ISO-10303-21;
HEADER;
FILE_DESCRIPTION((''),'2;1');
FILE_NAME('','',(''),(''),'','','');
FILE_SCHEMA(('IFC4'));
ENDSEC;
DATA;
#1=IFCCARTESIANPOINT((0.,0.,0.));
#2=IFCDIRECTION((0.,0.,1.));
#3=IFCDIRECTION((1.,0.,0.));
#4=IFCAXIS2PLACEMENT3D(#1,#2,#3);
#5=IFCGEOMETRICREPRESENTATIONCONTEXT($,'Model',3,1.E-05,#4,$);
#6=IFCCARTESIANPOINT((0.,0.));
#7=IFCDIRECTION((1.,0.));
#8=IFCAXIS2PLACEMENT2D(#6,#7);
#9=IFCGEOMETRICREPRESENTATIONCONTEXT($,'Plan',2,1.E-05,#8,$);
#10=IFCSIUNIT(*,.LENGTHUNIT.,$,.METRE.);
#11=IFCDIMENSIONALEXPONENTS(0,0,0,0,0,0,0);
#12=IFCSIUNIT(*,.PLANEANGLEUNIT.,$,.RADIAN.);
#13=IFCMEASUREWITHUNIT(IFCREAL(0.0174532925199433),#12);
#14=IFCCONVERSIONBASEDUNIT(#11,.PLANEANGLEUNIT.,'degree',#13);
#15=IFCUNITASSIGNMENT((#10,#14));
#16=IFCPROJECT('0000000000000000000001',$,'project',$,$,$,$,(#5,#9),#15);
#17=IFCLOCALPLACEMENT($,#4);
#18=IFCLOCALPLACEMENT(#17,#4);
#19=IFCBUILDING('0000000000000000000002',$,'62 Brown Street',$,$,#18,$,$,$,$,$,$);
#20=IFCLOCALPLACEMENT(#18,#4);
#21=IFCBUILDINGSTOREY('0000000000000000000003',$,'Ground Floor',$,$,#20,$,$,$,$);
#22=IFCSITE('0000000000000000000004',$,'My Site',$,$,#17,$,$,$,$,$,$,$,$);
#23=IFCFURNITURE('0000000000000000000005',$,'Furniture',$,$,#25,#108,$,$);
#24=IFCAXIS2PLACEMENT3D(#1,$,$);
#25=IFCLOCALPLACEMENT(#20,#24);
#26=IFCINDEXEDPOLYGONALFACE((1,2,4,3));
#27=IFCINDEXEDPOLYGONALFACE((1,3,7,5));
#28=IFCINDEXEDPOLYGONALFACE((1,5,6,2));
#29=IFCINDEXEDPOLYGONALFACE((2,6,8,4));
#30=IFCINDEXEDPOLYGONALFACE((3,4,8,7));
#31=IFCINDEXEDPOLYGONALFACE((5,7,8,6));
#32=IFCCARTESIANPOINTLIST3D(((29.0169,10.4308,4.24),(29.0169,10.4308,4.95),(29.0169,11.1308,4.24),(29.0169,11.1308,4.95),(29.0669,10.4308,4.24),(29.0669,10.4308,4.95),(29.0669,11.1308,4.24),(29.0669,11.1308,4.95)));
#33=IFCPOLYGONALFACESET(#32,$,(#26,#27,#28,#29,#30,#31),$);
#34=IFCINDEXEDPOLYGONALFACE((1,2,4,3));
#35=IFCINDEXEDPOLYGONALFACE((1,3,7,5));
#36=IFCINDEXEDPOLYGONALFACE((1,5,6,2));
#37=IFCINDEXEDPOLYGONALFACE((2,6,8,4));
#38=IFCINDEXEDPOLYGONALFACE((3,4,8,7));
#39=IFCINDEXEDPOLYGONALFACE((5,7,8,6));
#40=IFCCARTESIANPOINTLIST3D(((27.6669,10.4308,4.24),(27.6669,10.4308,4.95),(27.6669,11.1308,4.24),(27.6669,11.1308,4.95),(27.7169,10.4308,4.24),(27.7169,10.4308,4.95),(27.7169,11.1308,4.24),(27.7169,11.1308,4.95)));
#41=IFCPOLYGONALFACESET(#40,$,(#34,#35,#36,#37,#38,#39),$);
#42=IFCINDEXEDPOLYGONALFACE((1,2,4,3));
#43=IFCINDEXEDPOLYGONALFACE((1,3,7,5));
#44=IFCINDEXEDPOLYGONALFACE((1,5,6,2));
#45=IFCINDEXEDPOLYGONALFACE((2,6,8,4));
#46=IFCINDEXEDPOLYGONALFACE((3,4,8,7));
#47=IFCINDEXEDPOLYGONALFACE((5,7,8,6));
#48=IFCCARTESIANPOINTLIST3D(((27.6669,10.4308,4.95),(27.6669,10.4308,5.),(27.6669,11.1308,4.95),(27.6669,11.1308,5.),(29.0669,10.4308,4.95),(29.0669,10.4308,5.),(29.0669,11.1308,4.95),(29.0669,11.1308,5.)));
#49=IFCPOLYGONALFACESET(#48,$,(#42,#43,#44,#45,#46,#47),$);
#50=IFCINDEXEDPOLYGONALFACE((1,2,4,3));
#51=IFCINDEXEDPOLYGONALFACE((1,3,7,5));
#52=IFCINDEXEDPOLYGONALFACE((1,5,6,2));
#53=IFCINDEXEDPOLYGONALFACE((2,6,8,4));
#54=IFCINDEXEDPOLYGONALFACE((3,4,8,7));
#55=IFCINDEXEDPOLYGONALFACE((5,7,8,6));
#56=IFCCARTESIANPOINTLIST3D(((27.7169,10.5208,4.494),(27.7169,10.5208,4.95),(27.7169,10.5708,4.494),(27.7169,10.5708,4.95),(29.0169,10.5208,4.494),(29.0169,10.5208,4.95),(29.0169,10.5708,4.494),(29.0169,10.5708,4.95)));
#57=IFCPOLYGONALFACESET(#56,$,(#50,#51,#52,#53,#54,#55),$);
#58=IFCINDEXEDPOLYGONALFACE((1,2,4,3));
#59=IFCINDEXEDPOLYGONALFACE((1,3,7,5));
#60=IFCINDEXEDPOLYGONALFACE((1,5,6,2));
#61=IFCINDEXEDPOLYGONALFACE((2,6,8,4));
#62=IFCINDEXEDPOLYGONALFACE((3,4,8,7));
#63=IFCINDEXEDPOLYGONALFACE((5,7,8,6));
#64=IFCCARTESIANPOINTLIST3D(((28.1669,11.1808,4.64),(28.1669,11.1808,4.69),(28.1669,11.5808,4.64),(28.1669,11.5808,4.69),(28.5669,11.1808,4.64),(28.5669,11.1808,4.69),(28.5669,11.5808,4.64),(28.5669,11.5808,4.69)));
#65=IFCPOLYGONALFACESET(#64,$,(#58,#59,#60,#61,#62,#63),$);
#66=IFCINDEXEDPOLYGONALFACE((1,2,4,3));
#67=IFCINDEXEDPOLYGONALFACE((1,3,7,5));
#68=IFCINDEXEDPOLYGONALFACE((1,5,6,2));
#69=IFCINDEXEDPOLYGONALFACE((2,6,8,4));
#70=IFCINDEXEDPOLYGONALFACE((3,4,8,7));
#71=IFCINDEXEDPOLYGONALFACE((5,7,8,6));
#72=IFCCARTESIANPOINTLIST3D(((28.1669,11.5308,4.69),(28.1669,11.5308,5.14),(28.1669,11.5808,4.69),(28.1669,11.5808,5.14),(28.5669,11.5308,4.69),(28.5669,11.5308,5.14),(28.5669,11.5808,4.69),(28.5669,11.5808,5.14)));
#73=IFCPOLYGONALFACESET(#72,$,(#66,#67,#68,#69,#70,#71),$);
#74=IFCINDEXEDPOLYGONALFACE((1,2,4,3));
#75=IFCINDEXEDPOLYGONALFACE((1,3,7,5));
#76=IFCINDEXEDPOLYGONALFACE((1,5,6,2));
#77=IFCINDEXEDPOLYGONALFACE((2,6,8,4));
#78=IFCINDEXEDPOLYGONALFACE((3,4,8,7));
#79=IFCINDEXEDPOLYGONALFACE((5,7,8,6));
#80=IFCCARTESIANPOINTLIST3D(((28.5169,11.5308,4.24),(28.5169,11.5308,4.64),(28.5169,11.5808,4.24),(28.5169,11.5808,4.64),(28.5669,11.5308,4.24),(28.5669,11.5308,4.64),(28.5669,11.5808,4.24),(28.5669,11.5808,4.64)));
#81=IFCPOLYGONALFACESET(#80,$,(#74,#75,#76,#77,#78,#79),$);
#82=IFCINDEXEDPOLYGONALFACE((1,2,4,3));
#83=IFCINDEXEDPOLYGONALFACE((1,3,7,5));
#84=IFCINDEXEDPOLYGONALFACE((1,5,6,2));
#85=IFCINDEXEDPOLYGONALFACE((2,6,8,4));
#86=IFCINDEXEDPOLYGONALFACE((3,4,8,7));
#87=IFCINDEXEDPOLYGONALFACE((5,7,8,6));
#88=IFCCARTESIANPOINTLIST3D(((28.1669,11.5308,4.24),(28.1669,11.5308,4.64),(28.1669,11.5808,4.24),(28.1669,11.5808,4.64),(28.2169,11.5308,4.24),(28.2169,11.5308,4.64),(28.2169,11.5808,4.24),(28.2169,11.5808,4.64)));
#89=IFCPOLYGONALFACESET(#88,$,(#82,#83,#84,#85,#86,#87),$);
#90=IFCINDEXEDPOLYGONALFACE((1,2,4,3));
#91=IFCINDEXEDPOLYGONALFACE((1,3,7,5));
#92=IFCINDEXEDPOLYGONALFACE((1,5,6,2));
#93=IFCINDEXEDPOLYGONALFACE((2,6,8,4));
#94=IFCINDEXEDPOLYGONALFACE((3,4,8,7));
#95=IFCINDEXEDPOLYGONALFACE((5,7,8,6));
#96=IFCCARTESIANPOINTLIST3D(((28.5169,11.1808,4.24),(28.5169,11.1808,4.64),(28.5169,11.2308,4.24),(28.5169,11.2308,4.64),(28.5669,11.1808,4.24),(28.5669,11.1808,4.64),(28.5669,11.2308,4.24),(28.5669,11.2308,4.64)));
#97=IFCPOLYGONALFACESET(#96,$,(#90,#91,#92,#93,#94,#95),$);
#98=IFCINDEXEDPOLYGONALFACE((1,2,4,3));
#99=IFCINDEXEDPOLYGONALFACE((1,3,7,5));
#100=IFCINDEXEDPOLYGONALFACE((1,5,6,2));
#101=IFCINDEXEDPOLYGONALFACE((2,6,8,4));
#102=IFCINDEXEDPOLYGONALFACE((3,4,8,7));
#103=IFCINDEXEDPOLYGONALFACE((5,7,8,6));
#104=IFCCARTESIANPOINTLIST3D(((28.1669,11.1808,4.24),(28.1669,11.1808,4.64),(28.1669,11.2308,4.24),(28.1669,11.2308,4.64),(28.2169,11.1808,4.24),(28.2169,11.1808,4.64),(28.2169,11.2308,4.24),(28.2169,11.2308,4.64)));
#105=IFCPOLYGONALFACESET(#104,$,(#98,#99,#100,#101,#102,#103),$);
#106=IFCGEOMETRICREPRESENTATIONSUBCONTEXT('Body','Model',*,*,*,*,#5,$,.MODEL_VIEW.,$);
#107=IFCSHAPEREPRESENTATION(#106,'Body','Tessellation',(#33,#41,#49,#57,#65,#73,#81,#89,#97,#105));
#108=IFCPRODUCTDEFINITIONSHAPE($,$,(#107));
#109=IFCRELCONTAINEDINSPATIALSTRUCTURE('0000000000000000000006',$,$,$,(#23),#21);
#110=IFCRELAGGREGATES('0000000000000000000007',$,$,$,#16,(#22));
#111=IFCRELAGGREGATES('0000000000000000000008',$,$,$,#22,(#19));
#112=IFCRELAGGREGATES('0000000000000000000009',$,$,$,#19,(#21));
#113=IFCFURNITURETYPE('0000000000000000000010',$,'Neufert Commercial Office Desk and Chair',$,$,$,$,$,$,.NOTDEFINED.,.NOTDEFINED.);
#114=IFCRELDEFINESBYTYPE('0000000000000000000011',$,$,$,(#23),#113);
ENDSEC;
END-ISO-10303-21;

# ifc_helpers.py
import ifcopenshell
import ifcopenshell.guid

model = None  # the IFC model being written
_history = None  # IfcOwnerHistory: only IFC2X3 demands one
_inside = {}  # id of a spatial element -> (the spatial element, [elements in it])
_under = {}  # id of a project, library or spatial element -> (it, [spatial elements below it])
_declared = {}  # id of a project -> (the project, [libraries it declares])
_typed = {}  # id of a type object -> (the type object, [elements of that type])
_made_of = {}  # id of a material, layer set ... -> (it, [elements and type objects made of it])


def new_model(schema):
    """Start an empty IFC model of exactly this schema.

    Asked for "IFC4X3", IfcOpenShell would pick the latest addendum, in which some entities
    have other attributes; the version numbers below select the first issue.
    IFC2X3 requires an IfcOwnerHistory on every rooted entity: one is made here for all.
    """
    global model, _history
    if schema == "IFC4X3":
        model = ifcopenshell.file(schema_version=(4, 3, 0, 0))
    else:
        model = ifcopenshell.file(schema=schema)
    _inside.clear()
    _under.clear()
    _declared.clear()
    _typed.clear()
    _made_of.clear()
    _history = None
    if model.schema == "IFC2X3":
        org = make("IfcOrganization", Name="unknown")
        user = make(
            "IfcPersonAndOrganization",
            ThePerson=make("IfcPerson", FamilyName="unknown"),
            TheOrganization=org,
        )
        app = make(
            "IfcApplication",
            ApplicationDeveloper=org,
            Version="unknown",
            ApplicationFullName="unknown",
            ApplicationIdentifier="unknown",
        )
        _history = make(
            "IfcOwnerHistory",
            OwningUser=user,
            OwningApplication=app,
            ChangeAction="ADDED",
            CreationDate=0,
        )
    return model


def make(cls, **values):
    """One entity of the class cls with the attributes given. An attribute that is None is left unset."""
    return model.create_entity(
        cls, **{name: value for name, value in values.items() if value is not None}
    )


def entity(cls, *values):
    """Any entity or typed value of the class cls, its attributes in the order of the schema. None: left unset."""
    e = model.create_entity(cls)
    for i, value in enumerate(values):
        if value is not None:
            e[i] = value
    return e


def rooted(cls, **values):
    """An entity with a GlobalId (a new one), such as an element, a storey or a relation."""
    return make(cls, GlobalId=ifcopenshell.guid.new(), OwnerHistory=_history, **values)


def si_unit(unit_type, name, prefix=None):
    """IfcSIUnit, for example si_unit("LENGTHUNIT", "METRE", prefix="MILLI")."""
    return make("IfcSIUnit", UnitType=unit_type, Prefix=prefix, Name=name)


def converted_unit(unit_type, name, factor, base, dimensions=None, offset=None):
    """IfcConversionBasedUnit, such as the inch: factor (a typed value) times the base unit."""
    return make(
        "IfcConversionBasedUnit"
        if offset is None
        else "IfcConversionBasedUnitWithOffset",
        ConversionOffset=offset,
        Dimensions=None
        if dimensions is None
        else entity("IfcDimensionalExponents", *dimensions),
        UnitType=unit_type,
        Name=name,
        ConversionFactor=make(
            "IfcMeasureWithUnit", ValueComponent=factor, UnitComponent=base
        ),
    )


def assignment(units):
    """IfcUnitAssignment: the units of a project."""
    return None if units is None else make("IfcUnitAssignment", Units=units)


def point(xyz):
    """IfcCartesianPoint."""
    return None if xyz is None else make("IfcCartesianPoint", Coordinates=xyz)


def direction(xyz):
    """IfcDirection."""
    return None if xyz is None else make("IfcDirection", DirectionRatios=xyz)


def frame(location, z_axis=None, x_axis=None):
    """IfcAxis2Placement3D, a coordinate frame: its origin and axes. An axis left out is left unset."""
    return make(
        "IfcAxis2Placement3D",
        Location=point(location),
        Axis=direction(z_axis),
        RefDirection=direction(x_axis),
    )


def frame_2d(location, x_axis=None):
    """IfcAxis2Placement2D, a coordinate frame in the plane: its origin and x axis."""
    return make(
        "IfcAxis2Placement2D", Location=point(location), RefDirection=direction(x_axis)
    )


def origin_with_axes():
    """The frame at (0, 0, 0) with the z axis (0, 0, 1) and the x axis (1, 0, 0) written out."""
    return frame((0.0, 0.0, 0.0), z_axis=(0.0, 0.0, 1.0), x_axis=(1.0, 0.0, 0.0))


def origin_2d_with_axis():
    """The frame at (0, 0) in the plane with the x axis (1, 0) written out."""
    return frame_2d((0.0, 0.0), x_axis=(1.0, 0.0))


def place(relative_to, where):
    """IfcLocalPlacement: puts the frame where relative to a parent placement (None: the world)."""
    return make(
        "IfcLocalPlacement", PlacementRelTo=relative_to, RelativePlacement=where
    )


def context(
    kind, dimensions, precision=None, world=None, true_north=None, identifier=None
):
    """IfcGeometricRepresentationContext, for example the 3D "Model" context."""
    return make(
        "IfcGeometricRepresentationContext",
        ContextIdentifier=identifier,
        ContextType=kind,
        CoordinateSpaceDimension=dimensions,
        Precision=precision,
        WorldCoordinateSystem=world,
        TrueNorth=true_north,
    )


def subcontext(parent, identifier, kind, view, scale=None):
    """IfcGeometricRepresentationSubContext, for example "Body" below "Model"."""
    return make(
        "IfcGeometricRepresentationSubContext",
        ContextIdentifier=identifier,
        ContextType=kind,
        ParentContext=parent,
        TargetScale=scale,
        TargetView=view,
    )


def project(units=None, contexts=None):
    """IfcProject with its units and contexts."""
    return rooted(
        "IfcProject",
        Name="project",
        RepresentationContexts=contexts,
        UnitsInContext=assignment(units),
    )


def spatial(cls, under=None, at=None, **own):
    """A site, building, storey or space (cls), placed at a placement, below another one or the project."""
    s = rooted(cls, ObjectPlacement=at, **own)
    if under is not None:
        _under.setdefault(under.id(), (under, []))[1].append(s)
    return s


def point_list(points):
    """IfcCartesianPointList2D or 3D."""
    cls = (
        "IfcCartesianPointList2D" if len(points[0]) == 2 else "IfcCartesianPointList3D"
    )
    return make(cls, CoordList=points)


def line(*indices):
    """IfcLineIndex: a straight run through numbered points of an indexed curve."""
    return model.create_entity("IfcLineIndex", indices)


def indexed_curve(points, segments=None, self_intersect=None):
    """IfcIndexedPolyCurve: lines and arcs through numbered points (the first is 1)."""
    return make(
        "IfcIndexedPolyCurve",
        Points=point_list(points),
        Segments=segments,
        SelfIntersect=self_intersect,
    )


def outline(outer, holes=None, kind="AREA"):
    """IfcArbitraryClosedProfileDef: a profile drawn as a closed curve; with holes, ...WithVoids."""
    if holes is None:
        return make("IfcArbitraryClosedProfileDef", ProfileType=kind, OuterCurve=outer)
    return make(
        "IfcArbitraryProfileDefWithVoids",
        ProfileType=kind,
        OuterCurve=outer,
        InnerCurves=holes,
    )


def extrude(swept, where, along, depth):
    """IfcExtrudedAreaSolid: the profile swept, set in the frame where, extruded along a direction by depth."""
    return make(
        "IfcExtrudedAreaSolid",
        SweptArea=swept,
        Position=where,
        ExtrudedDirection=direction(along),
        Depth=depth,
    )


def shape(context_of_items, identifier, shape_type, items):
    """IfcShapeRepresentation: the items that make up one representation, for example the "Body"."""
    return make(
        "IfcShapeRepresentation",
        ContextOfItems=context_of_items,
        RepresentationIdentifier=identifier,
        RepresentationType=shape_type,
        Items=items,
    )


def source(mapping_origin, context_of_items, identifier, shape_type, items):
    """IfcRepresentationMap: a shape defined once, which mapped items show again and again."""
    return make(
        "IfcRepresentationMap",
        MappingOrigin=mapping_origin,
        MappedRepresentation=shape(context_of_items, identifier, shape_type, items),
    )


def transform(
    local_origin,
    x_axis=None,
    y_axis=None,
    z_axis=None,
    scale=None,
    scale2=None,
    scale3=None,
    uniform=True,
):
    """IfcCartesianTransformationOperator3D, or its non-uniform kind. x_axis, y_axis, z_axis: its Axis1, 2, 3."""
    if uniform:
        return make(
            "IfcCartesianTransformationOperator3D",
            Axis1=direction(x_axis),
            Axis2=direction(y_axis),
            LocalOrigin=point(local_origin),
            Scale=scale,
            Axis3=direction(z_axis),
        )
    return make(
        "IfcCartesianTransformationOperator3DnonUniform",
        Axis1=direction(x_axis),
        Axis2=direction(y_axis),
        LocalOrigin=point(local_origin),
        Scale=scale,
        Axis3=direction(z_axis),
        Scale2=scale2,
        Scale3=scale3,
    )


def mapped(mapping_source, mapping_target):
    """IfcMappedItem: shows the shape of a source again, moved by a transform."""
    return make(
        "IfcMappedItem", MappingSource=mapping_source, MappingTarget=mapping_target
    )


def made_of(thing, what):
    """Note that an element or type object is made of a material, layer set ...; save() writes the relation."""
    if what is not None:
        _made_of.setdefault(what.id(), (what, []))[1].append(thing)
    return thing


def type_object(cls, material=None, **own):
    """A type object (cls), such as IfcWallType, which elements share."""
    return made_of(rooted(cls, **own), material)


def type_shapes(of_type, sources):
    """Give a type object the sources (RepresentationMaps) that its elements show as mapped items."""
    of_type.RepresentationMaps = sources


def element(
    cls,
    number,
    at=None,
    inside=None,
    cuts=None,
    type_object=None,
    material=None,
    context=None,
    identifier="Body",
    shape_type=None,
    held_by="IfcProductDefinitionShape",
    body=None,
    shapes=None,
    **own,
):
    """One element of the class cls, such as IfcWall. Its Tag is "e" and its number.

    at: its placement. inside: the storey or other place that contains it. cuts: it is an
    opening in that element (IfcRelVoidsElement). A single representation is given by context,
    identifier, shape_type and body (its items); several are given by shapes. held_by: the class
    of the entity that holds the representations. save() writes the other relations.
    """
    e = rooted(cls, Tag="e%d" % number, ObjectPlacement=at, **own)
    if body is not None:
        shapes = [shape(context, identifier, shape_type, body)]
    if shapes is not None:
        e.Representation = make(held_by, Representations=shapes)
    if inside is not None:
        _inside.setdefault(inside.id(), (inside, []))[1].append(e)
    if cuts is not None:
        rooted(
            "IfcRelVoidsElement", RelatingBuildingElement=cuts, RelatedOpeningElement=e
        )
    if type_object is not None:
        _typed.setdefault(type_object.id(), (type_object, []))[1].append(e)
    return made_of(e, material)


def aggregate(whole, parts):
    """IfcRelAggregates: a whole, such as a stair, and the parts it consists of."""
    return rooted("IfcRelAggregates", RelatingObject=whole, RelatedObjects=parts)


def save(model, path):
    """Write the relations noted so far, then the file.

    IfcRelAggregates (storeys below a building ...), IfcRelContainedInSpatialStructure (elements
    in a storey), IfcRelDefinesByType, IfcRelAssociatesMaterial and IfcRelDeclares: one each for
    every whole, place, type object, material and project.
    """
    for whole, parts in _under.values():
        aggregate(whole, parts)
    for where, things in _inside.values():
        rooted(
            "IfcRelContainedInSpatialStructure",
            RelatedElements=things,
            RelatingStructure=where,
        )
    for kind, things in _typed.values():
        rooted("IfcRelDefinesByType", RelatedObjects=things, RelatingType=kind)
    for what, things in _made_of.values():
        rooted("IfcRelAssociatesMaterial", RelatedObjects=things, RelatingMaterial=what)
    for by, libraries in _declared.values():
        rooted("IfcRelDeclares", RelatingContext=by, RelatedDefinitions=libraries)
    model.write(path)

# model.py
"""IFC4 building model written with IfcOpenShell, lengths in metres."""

from ifc_helpers import new_model, entity, si_unit, converted_unit, frame, origin_with_axes, origin_2d_with_axis, place, context, subcontext, project, spatial, line, indexed_curve, outline, extrude, shape, source, transform, mapped, type_object, type_shapes, element, save


model = new_model("IFC4")

# Units and contexts
model_context = context("Model", 3, precision=1e-05, world=origin_with_axes())
plan_context = context("Plan", 2, precision=1e-05, world=origin_2d_with_axis())
body_context_1 = subcontext(model_context, "Body", "Model", "MODEL_VIEW")
body_context_2 = subcontext(plan_context, "Body", "Plan", "PLAN_VIEW")
ifc_project = project(units=[si_unit("LENGTHUNIT", "METRE"), converted_unit("PLANEANGLEUNIT", "degree", entity("IfcReal", 0.0174532925199433), si_unit("PLANEANGLEUNIT", "RADIAN"), dimensions=[0, 0, 0, 0, 0, 0, 0])], contexts=[model_context, plan_context])

# Site, building, storey
site_placement = place(None, origin_with_axes())
site = spatial("IfcSite", under=ifc_project, at=site_placement, Name="My Site")
building_placement = place(site_placement, origin_with_axes())
building = spatial("IfcBuilding", under=site, at=building_placement, Name="62 Brown Street")
storey_placement = place(building_placement, origin_with_axes())
storey = spatial("IfcBuildingStorey", under=building, at=storey_placement, Name="Ground Floor")

# Furniture
furniture_type_1 = type_object("IfcFurnitureType", Name="Neufert Commercial Office Desk and Chair", AssemblyPlace="NOTDEFINED", PredefinedType="NOTDEFINED")
shared_shape_1 = source(origin_with_axes(), body_context_1, "Body", "SweptSolid", [
    extrude(outline(indexed_curve([(0.0, 0.0), (0.05, 0.0), (0.05, 0.7), (0.0, 0.7)], segments=[line(1, 2, 3, 4, 1)])), frame((0.0, 0.45, 0.0), z_axis=(0.0, 0.0, 1.0), x_axis=(1.0, 0.0, 0.0)), (0.0, 0.0, 1.0), 0.71),
    extrude(outline(indexed_curve([(0.0, 0.0), (0.05, 0.0), (0.05, 0.7), (0.0, 0.7)], segments=[line(1, 2, 3, 4, 1)])), frame((1.35, 0.45, 0.0), z_axis=(0.0, 0.0, 1.0), x_axis=(1.0, 0.0, 0.0)), (0.0, 0.0, 1.0), 0.71),
    extrude(outline(indexed_curve([(0.0, 0.0), (1.4, 0.0), (1.4, 0.7), (0.0, 0.7)], segments=[line(1, 2, 3, 4, 1)])), frame((0.0, 0.45, 0.71), z_axis=(0.0, 0.0, 1.0), x_axis=(1.0, 0.0, 0.0)), (0.0, 0.0, 1.0), 0.05),
    extrude(outline(indexed_curve([(0.05, 0.56), (1.35, 0.56), (1.35, 0.61), (0.05, 0.61)], segments=[line(1, 2, 3, 4, 1)])), frame((0.0, 0.45, 0.254), z_axis=(0.0, 0.0, 1.0), x_axis=(1.0, 0.0, 0.0)), (0.0, 0.0, 1.0), 0.456),
    extrude(outline(indexed_curve([(-0.2, 0.0), (0.2, 0.0), (0.2, 0.4), (-0.2, 0.4)], segments=[line(1, 2, 3, 4, 1)])), frame((0.7, 0.0, 0.45), z_axis=(0.0, 0.0, 1.0), x_axis=(1.0, 0.0, 0.0)), (0.0, 0.0, -1.0), 0.05),
    extrude(outline(indexed_curve([(-0.2, 0.0), (0.2, 0.0), (0.2, 0.05), (-0.2, 0.05)], segments=[line(1, 2, 3, 4, 1)])), frame((0.7, 0.0, 0.9), z_axis=(0.0, 0.0, 1.0), x_axis=(1.0, 0.0, 0.0)), (0.0, 0.0, -1.0), 0.45),
    extrude(outline(indexed_curve([(-0.2, 0.0), (-0.15, 0.0), (-0.15, 0.05), (-0.2, 0.05)], segments=[line(1, 2, 3, 4, 1)])), frame((0.7, 0.0, 0.0), z_axis=(0.0, 0.0, 1.0), x_axis=(1.0, 0.0, 0.0)), (0.0, 0.0, 1.0), 0.4),
    extrude(outline(indexed_curve([(0.2, 0.0), (0.15, 0.0), (0.15, 0.05), (0.2, 0.05)], segments=[line(1, 2, 3, 4, 1)])), frame((0.7, 0.0, 0.0), z_axis=(0.0, 0.0, 1.0), x_axis=(1.0, 0.0, 0.0)), (0.0, 0.0, 1.0), 0.4),
    extrude(outline(indexed_curve([(-0.2, 0.4), (-0.15, 0.4), (-0.15, 0.35), (-0.2, 0.35)], segments=[line(1, 2, 3, 4, 1)])), frame((0.7, 0.0, 0.0), z_axis=(0.0, 0.0, 1.0), x_axis=(1.0, 0.0, 0.0)), (0.0, 0.0, 1.0), 0.4),
    extrude(outline(indexed_curve([(0.2, 0.4), (0.15, 0.4), (0.15, 0.35), (0.2, 0.35)], segments=[line(1, 2, 3, 4, 1)])), frame((0.7, 0.0, 0.0), z_axis=(0.0, 0.0, 1.0), x_axis=(1.0, 0.0, 0.0)), (0.0, 0.0, 1.0), 0.4),
])
shared_shape_2 = source(origin_with_axes(), body_context_2, "Body", "Curve2D", [
    entity("IfcIndexedPolyCurve", entity("IfcCartesianPointList2D", [[0.0, 0.45], [1.4, 0.45], [1.4, 1.15], [0.0, 1.15]]), [entity("IfcLineIndex", [1, 2, 3, 4, 1])]),
    entity("IfcIndexedPolyCurve", entity("IfcCartesianPointList2D", [[0.5, 0.4], [0.9, 0.4]])),
    entity("IfcIndexedPolyCurve", entity("IfcCartesianPointList2D", [[0.5, 0.4], [0.5, 0.2], [0.5586, 0.0586], [0.7, 0.0], [0.8414, 0.0586], [0.9, 0.2], [0.9, 0.4]]), [entity("IfcLineIndex", [1, 2]), entity("IfcArcIndex", [2, 3, 4]), entity("IfcArcIndex", [4, 5, 6]), entity("IfcLineIndex", [6, 7])]),
    entity("IfcIndexedPolyCurve", entity("IfcCartesianPointList2D", [[0.54, 0.4], [0.54, 0.2], [0.5869, 0.0869], [0.7, 0.04], [0.8131, 0.0869], [0.86, 0.2], [0.86, 0.4]]), [entity("IfcLineIndex", [1, 2]), entity("IfcArcIndex", [2, 3, 4]), entity("IfcArcIndex", [4, 5, 6]), entity("IfcLineIndex", [6, 7])]),
])
type_shapes(furniture_type_1, [shared_shape_1, shared_shape_2])
for number, where, z_axis, x_axis, name in (
    (1, (29.0669, 11.5808, 4.24), (0.0, 0.0, 1.0), (-1.0, 0.0, 0.0), "Furniture"),
):
    element("IfcFurniture", number, at=place(storey_placement, frame(where, z_axis=z_axis, x_axis=x_axis)), inside=storey, type_object=furniture_type_1, Name=name, shapes=[
        shape(body_context_1, "Body", "MappedRepresentation", [mapped(shared_shape_1, transform((0.0, 0.0, 0.0), x_axis=(1.0, 0.0, 0.0), y_axis=(0.0, 1.0, 0.0), z_axis=(0.0, 0.0, 1.0), scale=1.0))]),
        shape(body_context_2, "Body", "MappedRepresentation", [mapped(shared_shape_2, transform((0.0, 0.0, 0.0), x_axis=(1.0, 0.0, 0.0), y_axis=(0.0, 1.0, 0.0), z_axis=(0.0, 0.0, 1.0), scale=1.0))]),
    ])

save(model, "model.ifc")
